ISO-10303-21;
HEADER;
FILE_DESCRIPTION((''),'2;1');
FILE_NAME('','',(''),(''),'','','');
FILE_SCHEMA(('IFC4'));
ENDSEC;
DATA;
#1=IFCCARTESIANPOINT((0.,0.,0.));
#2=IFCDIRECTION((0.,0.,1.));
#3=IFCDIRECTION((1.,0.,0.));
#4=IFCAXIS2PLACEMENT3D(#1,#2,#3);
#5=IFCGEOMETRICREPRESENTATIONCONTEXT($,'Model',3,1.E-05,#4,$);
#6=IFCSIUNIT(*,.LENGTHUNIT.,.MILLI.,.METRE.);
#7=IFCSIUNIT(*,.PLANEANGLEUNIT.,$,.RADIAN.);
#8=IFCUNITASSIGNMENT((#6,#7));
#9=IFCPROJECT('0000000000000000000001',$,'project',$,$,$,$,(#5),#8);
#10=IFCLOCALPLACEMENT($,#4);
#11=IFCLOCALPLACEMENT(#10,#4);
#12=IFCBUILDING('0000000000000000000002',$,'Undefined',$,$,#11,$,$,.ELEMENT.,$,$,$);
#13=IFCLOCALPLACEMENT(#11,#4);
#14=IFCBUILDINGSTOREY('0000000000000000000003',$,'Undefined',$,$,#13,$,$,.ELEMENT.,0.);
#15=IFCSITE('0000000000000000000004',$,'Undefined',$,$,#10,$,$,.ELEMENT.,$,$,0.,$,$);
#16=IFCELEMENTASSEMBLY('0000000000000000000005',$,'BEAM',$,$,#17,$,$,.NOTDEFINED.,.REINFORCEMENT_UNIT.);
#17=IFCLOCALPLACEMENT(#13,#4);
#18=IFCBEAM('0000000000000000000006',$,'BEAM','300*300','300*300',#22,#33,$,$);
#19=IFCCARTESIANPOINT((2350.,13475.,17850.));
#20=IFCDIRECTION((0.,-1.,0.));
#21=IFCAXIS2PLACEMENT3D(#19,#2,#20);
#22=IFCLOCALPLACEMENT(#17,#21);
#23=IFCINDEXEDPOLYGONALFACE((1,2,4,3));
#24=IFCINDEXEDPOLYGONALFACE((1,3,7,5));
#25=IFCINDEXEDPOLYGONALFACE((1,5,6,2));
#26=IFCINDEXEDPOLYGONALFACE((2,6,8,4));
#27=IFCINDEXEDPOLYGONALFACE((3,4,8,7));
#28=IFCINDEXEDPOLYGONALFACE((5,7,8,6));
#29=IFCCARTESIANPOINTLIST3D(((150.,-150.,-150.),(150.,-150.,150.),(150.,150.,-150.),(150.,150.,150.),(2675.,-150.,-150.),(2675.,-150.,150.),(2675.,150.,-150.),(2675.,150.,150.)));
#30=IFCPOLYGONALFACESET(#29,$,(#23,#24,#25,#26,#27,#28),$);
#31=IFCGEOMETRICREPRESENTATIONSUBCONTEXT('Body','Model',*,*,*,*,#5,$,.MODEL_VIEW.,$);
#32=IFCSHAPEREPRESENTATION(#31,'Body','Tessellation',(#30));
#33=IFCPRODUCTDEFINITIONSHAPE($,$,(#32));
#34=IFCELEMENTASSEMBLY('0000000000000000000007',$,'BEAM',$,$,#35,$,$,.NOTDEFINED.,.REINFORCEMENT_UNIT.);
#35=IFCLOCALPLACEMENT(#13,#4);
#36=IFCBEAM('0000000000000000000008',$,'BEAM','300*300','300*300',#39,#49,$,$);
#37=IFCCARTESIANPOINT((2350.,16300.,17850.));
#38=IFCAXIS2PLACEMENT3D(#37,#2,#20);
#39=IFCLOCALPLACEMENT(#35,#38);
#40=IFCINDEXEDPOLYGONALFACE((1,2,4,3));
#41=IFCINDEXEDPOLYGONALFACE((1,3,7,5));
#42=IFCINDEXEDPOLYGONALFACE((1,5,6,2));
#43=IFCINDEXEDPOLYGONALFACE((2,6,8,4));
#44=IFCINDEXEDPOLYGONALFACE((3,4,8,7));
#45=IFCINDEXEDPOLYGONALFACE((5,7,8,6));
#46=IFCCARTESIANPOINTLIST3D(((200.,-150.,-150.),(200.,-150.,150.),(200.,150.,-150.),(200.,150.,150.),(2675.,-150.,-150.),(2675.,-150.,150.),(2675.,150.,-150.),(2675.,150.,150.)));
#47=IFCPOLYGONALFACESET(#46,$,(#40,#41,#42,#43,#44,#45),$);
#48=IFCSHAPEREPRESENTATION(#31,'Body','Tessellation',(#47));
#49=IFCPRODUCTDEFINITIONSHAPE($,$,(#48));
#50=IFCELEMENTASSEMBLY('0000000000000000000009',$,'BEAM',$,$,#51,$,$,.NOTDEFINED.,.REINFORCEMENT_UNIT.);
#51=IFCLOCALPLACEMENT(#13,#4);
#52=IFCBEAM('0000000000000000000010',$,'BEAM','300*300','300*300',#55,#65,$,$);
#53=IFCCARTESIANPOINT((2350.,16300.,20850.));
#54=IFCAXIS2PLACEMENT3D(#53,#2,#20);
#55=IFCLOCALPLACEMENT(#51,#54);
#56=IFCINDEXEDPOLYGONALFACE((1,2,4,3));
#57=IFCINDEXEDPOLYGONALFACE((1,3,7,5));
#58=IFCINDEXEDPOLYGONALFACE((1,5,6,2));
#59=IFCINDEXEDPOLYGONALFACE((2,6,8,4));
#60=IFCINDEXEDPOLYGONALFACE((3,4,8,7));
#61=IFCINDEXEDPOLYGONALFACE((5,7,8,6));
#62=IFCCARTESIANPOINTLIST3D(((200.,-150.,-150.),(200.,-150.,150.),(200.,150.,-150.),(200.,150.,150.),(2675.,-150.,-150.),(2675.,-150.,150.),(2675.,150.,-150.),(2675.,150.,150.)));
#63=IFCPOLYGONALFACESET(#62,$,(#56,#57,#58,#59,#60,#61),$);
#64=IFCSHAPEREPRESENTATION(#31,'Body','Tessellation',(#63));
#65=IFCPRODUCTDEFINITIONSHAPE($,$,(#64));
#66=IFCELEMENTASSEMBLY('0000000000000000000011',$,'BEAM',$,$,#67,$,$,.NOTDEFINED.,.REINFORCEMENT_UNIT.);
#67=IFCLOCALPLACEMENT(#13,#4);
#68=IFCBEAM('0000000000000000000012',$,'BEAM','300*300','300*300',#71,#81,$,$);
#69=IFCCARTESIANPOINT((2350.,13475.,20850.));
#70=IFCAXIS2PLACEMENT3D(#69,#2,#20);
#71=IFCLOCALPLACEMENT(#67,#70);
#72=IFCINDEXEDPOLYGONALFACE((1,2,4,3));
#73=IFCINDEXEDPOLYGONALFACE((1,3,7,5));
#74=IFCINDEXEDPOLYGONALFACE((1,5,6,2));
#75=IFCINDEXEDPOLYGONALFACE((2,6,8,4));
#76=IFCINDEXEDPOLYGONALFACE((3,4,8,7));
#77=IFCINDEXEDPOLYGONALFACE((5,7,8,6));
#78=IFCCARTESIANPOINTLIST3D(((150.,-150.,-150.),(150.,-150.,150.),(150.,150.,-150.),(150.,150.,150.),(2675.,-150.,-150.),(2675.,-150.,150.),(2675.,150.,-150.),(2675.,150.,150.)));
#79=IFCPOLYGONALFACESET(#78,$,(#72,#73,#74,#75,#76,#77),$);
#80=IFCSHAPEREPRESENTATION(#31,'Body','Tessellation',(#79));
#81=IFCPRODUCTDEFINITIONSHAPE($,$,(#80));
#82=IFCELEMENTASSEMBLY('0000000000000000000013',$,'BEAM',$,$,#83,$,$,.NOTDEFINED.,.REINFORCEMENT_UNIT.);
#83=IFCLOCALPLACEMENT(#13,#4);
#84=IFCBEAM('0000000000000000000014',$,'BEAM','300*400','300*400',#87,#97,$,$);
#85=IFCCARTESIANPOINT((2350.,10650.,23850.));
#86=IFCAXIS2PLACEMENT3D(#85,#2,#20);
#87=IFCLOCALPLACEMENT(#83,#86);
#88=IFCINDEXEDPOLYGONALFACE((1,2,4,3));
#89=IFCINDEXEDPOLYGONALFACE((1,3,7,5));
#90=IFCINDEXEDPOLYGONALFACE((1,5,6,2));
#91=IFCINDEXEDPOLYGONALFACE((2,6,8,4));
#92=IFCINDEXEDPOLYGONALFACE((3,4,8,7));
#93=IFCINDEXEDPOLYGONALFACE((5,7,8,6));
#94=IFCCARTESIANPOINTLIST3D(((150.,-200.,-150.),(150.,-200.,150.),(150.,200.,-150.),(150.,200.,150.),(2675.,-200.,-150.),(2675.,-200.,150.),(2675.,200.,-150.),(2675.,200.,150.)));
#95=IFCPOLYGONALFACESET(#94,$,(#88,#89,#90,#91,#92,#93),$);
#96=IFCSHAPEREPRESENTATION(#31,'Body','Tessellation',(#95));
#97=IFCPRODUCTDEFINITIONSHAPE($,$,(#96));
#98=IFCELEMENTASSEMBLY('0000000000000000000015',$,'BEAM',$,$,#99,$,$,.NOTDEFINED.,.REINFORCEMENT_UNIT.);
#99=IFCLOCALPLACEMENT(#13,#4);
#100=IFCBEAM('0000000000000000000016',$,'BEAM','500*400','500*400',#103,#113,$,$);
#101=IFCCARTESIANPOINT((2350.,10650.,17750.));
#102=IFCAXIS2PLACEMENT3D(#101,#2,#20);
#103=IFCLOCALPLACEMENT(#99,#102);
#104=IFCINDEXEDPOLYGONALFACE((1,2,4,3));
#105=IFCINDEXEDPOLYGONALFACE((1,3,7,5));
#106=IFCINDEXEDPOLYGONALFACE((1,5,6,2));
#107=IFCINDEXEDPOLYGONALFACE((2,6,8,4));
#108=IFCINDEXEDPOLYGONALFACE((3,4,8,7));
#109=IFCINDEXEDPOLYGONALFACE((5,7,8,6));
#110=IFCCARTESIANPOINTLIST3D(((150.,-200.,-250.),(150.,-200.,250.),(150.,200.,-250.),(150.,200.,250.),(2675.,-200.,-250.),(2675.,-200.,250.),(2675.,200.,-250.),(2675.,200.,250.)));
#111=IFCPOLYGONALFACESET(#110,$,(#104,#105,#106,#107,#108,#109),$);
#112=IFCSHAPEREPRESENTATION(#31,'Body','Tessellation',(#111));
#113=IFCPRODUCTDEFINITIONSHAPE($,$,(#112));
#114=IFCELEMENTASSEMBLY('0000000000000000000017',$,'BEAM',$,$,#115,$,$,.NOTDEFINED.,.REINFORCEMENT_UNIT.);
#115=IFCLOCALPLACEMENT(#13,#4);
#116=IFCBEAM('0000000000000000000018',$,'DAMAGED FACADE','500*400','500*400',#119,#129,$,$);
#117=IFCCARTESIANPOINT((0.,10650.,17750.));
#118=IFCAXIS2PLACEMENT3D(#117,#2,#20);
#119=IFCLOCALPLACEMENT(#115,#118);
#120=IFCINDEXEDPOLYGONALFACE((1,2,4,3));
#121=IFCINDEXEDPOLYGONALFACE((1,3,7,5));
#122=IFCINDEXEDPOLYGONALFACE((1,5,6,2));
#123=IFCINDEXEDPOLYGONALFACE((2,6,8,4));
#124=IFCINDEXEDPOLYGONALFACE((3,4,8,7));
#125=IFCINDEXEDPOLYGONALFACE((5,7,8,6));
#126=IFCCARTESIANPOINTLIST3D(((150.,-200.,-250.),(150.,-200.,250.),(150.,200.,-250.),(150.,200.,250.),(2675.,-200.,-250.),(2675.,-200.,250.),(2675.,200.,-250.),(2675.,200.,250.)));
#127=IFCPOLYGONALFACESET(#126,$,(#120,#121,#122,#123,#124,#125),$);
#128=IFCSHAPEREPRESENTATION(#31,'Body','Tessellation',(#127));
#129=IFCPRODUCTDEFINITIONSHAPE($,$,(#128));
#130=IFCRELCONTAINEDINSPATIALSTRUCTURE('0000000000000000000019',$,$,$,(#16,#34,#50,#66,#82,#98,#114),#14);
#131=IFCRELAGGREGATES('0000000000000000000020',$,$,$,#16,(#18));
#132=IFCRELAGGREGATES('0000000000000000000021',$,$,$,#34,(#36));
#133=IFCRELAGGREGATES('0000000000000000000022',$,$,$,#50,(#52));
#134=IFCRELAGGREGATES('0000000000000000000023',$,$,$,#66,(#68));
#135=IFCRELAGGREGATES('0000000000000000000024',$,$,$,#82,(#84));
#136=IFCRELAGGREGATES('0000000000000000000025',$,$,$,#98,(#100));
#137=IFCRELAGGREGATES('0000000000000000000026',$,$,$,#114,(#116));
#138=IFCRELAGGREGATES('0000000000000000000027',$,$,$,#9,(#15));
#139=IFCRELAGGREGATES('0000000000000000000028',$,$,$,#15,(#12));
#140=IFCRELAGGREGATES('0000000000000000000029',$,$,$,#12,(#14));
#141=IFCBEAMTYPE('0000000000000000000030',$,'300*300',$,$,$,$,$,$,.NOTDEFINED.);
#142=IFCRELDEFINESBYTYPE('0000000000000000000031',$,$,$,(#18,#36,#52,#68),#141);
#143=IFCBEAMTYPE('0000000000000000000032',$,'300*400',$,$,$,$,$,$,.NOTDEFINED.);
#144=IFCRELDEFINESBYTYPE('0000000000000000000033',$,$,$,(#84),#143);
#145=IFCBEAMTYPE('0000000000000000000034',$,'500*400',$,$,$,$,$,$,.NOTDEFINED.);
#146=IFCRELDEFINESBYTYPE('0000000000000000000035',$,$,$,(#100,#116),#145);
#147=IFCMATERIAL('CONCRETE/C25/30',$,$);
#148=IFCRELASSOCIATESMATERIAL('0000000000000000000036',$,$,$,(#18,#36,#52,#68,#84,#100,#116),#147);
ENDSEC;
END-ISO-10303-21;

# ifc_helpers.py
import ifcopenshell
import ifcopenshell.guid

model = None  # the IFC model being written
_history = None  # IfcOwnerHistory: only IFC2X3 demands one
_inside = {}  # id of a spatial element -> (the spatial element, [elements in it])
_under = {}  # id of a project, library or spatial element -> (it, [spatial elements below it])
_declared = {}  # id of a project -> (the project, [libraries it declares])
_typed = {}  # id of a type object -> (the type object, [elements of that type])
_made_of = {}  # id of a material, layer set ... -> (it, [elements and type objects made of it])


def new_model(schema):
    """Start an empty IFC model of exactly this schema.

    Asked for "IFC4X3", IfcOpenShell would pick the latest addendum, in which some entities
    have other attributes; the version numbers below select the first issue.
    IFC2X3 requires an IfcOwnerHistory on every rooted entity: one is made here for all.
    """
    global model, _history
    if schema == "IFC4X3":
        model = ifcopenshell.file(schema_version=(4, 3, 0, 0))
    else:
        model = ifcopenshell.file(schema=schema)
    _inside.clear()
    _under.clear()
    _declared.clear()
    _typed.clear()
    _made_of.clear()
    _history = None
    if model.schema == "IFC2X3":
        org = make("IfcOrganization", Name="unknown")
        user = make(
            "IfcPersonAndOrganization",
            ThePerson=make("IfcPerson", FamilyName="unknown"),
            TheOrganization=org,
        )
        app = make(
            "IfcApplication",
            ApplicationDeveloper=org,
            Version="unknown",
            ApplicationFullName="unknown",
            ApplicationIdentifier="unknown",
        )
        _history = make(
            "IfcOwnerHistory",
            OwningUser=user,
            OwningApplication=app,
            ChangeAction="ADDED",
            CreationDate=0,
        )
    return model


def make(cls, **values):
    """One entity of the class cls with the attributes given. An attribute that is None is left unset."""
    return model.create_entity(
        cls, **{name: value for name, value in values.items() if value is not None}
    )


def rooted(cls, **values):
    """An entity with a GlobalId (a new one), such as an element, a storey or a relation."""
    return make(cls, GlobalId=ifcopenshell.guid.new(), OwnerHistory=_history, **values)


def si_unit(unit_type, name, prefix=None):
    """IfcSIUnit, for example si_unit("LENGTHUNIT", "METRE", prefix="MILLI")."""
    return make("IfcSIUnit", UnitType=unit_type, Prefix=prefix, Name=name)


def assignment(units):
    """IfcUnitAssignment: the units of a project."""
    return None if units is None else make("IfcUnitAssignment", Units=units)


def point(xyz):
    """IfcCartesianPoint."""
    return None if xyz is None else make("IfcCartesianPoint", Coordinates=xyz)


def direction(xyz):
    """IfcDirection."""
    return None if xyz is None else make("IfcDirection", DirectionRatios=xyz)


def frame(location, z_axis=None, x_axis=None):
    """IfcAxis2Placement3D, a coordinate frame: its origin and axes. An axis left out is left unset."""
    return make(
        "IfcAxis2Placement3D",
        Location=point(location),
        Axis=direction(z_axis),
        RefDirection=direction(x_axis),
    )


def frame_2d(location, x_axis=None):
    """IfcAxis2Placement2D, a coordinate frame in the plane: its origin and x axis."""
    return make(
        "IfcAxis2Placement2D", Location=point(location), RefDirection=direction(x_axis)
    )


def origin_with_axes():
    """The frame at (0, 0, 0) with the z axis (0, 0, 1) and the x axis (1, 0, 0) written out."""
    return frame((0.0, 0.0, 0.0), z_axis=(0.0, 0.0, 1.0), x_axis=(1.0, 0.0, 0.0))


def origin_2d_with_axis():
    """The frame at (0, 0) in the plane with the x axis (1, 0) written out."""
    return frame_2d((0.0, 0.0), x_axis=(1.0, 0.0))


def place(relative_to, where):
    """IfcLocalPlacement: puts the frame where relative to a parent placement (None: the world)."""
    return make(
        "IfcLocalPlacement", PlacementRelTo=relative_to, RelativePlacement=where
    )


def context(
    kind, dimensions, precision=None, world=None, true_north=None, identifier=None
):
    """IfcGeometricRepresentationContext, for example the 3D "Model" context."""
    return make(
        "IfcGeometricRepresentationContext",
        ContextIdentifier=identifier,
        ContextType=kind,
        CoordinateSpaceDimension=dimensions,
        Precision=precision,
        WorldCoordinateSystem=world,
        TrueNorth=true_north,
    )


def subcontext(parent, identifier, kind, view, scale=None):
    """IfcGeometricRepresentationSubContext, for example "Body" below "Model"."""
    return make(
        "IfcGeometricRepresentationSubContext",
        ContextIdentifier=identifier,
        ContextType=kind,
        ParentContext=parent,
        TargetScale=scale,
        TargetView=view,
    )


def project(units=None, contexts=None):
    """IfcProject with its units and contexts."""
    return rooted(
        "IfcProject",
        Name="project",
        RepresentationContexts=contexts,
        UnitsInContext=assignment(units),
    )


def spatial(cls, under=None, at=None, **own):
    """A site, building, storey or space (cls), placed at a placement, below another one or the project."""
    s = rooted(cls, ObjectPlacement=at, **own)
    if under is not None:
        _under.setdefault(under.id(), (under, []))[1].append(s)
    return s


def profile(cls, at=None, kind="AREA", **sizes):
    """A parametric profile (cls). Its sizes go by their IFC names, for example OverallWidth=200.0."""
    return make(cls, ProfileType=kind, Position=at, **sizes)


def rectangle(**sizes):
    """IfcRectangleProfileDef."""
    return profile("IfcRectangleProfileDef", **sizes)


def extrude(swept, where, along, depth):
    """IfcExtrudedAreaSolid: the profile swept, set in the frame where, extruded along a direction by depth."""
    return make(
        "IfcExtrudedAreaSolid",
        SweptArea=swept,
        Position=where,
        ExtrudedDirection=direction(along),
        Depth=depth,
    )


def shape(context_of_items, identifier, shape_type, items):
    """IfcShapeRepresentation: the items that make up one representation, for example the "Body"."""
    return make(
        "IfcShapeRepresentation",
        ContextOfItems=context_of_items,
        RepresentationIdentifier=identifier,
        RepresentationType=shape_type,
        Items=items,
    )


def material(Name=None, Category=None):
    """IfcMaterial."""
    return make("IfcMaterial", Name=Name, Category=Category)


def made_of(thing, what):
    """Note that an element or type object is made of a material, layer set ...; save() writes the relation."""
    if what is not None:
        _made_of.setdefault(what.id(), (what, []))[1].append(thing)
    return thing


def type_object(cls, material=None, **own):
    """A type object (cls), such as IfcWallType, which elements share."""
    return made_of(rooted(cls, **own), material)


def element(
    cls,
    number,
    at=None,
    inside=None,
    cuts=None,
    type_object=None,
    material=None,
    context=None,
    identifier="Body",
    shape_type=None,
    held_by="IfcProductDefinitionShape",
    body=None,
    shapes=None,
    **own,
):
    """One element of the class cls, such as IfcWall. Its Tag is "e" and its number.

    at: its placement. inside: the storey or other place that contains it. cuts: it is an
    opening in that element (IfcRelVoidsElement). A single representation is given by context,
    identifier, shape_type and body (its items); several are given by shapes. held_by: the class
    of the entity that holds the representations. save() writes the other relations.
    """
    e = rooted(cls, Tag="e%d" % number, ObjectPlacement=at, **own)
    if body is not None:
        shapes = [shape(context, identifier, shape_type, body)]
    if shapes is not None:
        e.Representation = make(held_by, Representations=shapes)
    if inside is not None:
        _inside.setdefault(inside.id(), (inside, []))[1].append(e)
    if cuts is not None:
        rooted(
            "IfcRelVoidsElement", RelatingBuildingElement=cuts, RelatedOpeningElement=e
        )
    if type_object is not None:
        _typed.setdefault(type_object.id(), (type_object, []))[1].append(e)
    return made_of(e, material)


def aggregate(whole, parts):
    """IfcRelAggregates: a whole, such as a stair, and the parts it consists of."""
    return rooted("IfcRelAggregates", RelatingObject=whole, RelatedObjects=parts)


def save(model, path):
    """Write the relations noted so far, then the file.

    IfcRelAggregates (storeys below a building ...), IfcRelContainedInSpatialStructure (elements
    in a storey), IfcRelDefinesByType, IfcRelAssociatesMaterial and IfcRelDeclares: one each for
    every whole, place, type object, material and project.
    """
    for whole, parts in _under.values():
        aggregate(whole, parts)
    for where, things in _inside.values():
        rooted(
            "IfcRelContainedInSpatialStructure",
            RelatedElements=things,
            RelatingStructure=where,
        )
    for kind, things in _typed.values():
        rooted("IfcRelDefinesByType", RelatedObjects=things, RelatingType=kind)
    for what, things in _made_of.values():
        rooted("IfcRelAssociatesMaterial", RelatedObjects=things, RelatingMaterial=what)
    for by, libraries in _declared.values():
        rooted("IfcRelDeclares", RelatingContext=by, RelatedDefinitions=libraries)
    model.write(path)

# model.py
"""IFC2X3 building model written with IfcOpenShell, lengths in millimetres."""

from ifc_helpers import new_model, si_unit, frame, origin_with_axes, origin_2d_with_axis, place, context, subcontext, project, spatial, rectangle, extrude, material, type_object, element, aggregate, save


model = new_model("IFC2X3")

# Units and contexts
model_context = context("Model", 3, precision=1e-05, world=origin_with_axes())
body_context = subcontext(model_context, "Body", "Model", "MODEL_VIEW")
ifc_project = project(units=[si_unit("LENGTHUNIT", "METRE", prefix="MILLI"), si_unit("PLANEANGLEUNIT", "RADIAN")], contexts=[model_context])

# Site, building, storey
site_placement = place(None, origin_with_axes())
site = spatial("IfcSite", under=ifc_project, at=site_placement, Name="Undefined", CompositionType="ELEMENT", RefElevation=0.0)
building_placement = place(site_placement, origin_with_axes())
building = spatial("IfcBuilding", under=site, at=building_placement, Name="Undefined", CompositionType="ELEMENT")
storey_placement = place(building_placement, origin_with_axes())
storey = spatial("IfcBuildingStorey", under=building, at=storey_placement, Name="Undefined", CompositionType="ELEMENT", Elevation=0.0)

# Shared definitions
ifc_material = material(Name="CONCRETE/C25/30")

# Element assemblies, beams
assembly_1_placement = place(storey_placement, origin_with_axes())
assembly_1 = element("IfcElementAssembly", 1, at=assembly_1_placement, inside=storey, Name="BEAM", AssemblyPlace="NOTDEFINED", PredefinedType="REINFORCEMENT_UNIT")
beam_type_1 = type_object("IfcBeamType", Name="300*300", PredefinedType="NOTDEFINED")
beam_1_placement = place(assembly_1_placement, frame((2350.0, 13475.0, 17850.0), z_axis=(0.0, 0.0, 1.0), x_axis=(0.0, -1.0, 0.0)))
beam_1 = element("IfcBeam", 2, at=beam_1_placement, type_object=beam_type_1, material=ifc_material, Name="BEAM", Description="300*300", ObjectType="300*300", context=body_context, shape_type="SweptSolid", body=[
    extrude(rectangle(XDim=300.0, YDim=300.0, at=origin_2d_with_axis()), frame((2675.0, 0.0, 0.0), z_axis=(-1.0, 0.0, 0.0), x_axis=(0.0, -1.0, 0.0)), (0.0, 0.0, 1.0), 2525.0),
])
aggregate(assembly_1, [beam_1])
assembly_2_placement = place(storey_placement, origin_with_axes())
assembly_2 = element("IfcElementAssembly", 3, at=assembly_2_placement, inside=storey, Name="BEAM", AssemblyPlace="NOTDEFINED", PredefinedType="REINFORCEMENT_UNIT")
beam_2_placement = place(assembly_2_placement, frame((2350.0, 16300.0, 17850.0), z_axis=(0.0, 0.0, 1.0), x_axis=(0.0, -1.0, 0.0)))
beam_2 = element("IfcBeam", 4, at=beam_2_placement, type_object=beam_type_1, material=ifc_material, Name="BEAM", Description="300*300", ObjectType="300*300", context=body_context, shape_type="SweptSolid", body=[
    extrude(rectangle(XDim=300.0, YDim=300.0, at=origin_2d_with_axis()), frame((2675.0, 0.0, 0.0), z_axis=(-1.0, 0.0, 0.0), x_axis=(0.0, -1.0, 0.0)), (0.0, 0.0, 1.0), 2475.0),
])
aggregate(assembly_2, [beam_2])
assembly_3_placement = place(storey_placement, origin_with_axes())
assembly_3 = element("IfcElementAssembly", 5, at=assembly_3_placement, inside=storey, Name="BEAM", AssemblyPlace="NOTDEFINED", PredefinedType="REINFORCEMENT_UNIT")
beam_3_placement = place(assembly_3_placement, frame((2350.0, 16300.0, 20850.0), z_axis=(0.0, 0.0, 1.0), x_axis=(0.0, -1.0, 0.0)))
beam_3 = element("IfcBeam", 6, at=beam_3_placement, type_object=beam_type_1, material=ifc_material, Name="BEAM", Description="300*300", ObjectType="300*300", context=body_context, shape_type="SweptSolid", body=[
    extrude(rectangle(XDim=300.0, YDim=300.0, at=origin_2d_with_axis()), frame((2675.0, 0.0, 0.0), z_axis=(-1.0, 0.0, 0.0), x_axis=(0.0, -1.0, 0.0)), (0.0, 0.0, 1.0), 2475.0),
])
aggregate(assembly_3, [beam_3])
assembly_4_placement = place(storey_placement, origin_with_axes())
assembly_4 = element("IfcElementAssembly", 7, at=assembly_4_placement, inside=storey, Name="BEAM", AssemblyPlace="NOTDEFINED", PredefinedType="REINFORCEMENT_UNIT")
beam_4_placement = place(assembly_4_placement, frame((2350.0, 13475.0, 20850.0), z_axis=(0.0, 0.0, 1.0), x_axis=(0.0, -1.0, 0.0)))
beam_4 = element("IfcBeam", 8, at=beam_4_placement, type_object=beam_type_1, material=ifc_material, Name="BEAM", Description="300*300", ObjectType="300*300", context=body_context, shape_type="SweptSolid", body=[
    extrude(rectangle(XDim=300.0, YDim=300.0, at=origin_2d_with_axis()), frame((2675.0, 0.0, 0.0), z_axis=(-1.0, 0.0, 0.0), x_axis=(0.0, -1.0, 0.0)), (0.0, 0.0, 1.0), 2525.0),
])
aggregate(assembly_4, [beam_4])
assembly_5_placement = place(storey_placement, origin_with_axes())
assembly_5 = element("IfcElementAssembly", 9, at=assembly_5_placement, inside=storey, Name="BEAM", AssemblyPlace="NOTDEFINED", PredefinedType="REINFORCEMENT_UNIT")
beam_type_2 = type_object("IfcBeamType", Name="300*400", PredefinedType="NOTDEFINED")
beam_5_placement = place(assembly_5_placement, frame((2350.0, 10650.0, 23850.0), z_axis=(0.0, 0.0, 1.0), x_axis=(0.0, -1.0, 0.0)))
beam_5 = element("IfcBeam", 10, at=beam_5_placement, type_object=beam_type_2, material=ifc_material, Name="BEAM", Description="300*400", ObjectType="300*400", context=body_context, shape_type="SweptSolid", body=[
    extrude(rectangle(XDim=400.0, YDim=300.0, at=origin_2d_with_axis()), frame((2675.0, 0.0, 0.0), z_axis=(-1.0, 0.0, 0.0), x_axis=(0.0, -1.0, 0.0)), (0.0, 0.0, 1.0), 2525.0),
])
aggregate(assembly_5, [beam_5])
assembly_6_placement = place(storey_placement, origin_with_axes())
assembly_6 = element("IfcElementAssembly", 11, at=assembly_6_placement, inside=storey, Name="BEAM", AssemblyPlace="NOTDEFINED", PredefinedType="REINFORCEMENT_UNIT")
beam_type_3 = type_object("IfcBeamType", Name="500*400", PredefinedType="NOTDEFINED")
beam_6_placement = place(assembly_6_placement, frame((2350.0, 10650.0, 17750.0), z_axis=(0.0, 0.0, 1.0), x_axis=(0.0, -1.0, 0.0)))
beam_6 = element("IfcBeam", 12, at=beam_6_placement, type_object=beam_type_3, material=ifc_material, Name="BEAM", Description="500*400", ObjectType="500*400", context=body_context, shape_type="SweptSolid", body=[
    extrude(rectangle(XDim=400.0, YDim=500.0, at=origin_2d_with_axis()), frame((2675.0, 0.0, 0.0), z_axis=(-1.0, 0.0, 0.0), x_axis=(0.0, -1.0, 0.0)), (0.0, 0.0, 1.0), 2525.0),
])
aggregate(assembly_6, [beam_6])
assembly_7_placement = place(storey_placement, origin_with_axes())
assembly_7 = element("IfcElementAssembly", 13, at=assembly_7_placement, inside=storey, Name="BEAM", AssemblyPlace="NOTDEFINED", PredefinedType="REINFORCEMENT_UNIT")
beam_7_placement = place(assembly_7_placement, frame((0.0, 10650.0, 17750.0), z_axis=(0.0, 0.0, 1.0), x_axis=(0.0, -1.0, 0.0)))
beam_7 = element("IfcBeam", 14, at=beam_7_placement, type_object=beam_type_3, material=ifc_material, Name="DAMAGED FACADE", Description="500*400", ObjectType="500*400", context=body_context, shape_type="SweptSolid", body=[
    extrude(rectangle(XDim=400.0, YDim=500.0, at=origin_2d_with_axis()), frame((2675.0, 0.0, 0.0), z_axis=(-1.0, 0.0, 0.0), x_axis=(0.0, -1.0, 0.0)), (0.0, 0.0, 1.0), 2525.0),
])
aggregate(assembly_7, [beam_7])

save(model, "model.ifc")
